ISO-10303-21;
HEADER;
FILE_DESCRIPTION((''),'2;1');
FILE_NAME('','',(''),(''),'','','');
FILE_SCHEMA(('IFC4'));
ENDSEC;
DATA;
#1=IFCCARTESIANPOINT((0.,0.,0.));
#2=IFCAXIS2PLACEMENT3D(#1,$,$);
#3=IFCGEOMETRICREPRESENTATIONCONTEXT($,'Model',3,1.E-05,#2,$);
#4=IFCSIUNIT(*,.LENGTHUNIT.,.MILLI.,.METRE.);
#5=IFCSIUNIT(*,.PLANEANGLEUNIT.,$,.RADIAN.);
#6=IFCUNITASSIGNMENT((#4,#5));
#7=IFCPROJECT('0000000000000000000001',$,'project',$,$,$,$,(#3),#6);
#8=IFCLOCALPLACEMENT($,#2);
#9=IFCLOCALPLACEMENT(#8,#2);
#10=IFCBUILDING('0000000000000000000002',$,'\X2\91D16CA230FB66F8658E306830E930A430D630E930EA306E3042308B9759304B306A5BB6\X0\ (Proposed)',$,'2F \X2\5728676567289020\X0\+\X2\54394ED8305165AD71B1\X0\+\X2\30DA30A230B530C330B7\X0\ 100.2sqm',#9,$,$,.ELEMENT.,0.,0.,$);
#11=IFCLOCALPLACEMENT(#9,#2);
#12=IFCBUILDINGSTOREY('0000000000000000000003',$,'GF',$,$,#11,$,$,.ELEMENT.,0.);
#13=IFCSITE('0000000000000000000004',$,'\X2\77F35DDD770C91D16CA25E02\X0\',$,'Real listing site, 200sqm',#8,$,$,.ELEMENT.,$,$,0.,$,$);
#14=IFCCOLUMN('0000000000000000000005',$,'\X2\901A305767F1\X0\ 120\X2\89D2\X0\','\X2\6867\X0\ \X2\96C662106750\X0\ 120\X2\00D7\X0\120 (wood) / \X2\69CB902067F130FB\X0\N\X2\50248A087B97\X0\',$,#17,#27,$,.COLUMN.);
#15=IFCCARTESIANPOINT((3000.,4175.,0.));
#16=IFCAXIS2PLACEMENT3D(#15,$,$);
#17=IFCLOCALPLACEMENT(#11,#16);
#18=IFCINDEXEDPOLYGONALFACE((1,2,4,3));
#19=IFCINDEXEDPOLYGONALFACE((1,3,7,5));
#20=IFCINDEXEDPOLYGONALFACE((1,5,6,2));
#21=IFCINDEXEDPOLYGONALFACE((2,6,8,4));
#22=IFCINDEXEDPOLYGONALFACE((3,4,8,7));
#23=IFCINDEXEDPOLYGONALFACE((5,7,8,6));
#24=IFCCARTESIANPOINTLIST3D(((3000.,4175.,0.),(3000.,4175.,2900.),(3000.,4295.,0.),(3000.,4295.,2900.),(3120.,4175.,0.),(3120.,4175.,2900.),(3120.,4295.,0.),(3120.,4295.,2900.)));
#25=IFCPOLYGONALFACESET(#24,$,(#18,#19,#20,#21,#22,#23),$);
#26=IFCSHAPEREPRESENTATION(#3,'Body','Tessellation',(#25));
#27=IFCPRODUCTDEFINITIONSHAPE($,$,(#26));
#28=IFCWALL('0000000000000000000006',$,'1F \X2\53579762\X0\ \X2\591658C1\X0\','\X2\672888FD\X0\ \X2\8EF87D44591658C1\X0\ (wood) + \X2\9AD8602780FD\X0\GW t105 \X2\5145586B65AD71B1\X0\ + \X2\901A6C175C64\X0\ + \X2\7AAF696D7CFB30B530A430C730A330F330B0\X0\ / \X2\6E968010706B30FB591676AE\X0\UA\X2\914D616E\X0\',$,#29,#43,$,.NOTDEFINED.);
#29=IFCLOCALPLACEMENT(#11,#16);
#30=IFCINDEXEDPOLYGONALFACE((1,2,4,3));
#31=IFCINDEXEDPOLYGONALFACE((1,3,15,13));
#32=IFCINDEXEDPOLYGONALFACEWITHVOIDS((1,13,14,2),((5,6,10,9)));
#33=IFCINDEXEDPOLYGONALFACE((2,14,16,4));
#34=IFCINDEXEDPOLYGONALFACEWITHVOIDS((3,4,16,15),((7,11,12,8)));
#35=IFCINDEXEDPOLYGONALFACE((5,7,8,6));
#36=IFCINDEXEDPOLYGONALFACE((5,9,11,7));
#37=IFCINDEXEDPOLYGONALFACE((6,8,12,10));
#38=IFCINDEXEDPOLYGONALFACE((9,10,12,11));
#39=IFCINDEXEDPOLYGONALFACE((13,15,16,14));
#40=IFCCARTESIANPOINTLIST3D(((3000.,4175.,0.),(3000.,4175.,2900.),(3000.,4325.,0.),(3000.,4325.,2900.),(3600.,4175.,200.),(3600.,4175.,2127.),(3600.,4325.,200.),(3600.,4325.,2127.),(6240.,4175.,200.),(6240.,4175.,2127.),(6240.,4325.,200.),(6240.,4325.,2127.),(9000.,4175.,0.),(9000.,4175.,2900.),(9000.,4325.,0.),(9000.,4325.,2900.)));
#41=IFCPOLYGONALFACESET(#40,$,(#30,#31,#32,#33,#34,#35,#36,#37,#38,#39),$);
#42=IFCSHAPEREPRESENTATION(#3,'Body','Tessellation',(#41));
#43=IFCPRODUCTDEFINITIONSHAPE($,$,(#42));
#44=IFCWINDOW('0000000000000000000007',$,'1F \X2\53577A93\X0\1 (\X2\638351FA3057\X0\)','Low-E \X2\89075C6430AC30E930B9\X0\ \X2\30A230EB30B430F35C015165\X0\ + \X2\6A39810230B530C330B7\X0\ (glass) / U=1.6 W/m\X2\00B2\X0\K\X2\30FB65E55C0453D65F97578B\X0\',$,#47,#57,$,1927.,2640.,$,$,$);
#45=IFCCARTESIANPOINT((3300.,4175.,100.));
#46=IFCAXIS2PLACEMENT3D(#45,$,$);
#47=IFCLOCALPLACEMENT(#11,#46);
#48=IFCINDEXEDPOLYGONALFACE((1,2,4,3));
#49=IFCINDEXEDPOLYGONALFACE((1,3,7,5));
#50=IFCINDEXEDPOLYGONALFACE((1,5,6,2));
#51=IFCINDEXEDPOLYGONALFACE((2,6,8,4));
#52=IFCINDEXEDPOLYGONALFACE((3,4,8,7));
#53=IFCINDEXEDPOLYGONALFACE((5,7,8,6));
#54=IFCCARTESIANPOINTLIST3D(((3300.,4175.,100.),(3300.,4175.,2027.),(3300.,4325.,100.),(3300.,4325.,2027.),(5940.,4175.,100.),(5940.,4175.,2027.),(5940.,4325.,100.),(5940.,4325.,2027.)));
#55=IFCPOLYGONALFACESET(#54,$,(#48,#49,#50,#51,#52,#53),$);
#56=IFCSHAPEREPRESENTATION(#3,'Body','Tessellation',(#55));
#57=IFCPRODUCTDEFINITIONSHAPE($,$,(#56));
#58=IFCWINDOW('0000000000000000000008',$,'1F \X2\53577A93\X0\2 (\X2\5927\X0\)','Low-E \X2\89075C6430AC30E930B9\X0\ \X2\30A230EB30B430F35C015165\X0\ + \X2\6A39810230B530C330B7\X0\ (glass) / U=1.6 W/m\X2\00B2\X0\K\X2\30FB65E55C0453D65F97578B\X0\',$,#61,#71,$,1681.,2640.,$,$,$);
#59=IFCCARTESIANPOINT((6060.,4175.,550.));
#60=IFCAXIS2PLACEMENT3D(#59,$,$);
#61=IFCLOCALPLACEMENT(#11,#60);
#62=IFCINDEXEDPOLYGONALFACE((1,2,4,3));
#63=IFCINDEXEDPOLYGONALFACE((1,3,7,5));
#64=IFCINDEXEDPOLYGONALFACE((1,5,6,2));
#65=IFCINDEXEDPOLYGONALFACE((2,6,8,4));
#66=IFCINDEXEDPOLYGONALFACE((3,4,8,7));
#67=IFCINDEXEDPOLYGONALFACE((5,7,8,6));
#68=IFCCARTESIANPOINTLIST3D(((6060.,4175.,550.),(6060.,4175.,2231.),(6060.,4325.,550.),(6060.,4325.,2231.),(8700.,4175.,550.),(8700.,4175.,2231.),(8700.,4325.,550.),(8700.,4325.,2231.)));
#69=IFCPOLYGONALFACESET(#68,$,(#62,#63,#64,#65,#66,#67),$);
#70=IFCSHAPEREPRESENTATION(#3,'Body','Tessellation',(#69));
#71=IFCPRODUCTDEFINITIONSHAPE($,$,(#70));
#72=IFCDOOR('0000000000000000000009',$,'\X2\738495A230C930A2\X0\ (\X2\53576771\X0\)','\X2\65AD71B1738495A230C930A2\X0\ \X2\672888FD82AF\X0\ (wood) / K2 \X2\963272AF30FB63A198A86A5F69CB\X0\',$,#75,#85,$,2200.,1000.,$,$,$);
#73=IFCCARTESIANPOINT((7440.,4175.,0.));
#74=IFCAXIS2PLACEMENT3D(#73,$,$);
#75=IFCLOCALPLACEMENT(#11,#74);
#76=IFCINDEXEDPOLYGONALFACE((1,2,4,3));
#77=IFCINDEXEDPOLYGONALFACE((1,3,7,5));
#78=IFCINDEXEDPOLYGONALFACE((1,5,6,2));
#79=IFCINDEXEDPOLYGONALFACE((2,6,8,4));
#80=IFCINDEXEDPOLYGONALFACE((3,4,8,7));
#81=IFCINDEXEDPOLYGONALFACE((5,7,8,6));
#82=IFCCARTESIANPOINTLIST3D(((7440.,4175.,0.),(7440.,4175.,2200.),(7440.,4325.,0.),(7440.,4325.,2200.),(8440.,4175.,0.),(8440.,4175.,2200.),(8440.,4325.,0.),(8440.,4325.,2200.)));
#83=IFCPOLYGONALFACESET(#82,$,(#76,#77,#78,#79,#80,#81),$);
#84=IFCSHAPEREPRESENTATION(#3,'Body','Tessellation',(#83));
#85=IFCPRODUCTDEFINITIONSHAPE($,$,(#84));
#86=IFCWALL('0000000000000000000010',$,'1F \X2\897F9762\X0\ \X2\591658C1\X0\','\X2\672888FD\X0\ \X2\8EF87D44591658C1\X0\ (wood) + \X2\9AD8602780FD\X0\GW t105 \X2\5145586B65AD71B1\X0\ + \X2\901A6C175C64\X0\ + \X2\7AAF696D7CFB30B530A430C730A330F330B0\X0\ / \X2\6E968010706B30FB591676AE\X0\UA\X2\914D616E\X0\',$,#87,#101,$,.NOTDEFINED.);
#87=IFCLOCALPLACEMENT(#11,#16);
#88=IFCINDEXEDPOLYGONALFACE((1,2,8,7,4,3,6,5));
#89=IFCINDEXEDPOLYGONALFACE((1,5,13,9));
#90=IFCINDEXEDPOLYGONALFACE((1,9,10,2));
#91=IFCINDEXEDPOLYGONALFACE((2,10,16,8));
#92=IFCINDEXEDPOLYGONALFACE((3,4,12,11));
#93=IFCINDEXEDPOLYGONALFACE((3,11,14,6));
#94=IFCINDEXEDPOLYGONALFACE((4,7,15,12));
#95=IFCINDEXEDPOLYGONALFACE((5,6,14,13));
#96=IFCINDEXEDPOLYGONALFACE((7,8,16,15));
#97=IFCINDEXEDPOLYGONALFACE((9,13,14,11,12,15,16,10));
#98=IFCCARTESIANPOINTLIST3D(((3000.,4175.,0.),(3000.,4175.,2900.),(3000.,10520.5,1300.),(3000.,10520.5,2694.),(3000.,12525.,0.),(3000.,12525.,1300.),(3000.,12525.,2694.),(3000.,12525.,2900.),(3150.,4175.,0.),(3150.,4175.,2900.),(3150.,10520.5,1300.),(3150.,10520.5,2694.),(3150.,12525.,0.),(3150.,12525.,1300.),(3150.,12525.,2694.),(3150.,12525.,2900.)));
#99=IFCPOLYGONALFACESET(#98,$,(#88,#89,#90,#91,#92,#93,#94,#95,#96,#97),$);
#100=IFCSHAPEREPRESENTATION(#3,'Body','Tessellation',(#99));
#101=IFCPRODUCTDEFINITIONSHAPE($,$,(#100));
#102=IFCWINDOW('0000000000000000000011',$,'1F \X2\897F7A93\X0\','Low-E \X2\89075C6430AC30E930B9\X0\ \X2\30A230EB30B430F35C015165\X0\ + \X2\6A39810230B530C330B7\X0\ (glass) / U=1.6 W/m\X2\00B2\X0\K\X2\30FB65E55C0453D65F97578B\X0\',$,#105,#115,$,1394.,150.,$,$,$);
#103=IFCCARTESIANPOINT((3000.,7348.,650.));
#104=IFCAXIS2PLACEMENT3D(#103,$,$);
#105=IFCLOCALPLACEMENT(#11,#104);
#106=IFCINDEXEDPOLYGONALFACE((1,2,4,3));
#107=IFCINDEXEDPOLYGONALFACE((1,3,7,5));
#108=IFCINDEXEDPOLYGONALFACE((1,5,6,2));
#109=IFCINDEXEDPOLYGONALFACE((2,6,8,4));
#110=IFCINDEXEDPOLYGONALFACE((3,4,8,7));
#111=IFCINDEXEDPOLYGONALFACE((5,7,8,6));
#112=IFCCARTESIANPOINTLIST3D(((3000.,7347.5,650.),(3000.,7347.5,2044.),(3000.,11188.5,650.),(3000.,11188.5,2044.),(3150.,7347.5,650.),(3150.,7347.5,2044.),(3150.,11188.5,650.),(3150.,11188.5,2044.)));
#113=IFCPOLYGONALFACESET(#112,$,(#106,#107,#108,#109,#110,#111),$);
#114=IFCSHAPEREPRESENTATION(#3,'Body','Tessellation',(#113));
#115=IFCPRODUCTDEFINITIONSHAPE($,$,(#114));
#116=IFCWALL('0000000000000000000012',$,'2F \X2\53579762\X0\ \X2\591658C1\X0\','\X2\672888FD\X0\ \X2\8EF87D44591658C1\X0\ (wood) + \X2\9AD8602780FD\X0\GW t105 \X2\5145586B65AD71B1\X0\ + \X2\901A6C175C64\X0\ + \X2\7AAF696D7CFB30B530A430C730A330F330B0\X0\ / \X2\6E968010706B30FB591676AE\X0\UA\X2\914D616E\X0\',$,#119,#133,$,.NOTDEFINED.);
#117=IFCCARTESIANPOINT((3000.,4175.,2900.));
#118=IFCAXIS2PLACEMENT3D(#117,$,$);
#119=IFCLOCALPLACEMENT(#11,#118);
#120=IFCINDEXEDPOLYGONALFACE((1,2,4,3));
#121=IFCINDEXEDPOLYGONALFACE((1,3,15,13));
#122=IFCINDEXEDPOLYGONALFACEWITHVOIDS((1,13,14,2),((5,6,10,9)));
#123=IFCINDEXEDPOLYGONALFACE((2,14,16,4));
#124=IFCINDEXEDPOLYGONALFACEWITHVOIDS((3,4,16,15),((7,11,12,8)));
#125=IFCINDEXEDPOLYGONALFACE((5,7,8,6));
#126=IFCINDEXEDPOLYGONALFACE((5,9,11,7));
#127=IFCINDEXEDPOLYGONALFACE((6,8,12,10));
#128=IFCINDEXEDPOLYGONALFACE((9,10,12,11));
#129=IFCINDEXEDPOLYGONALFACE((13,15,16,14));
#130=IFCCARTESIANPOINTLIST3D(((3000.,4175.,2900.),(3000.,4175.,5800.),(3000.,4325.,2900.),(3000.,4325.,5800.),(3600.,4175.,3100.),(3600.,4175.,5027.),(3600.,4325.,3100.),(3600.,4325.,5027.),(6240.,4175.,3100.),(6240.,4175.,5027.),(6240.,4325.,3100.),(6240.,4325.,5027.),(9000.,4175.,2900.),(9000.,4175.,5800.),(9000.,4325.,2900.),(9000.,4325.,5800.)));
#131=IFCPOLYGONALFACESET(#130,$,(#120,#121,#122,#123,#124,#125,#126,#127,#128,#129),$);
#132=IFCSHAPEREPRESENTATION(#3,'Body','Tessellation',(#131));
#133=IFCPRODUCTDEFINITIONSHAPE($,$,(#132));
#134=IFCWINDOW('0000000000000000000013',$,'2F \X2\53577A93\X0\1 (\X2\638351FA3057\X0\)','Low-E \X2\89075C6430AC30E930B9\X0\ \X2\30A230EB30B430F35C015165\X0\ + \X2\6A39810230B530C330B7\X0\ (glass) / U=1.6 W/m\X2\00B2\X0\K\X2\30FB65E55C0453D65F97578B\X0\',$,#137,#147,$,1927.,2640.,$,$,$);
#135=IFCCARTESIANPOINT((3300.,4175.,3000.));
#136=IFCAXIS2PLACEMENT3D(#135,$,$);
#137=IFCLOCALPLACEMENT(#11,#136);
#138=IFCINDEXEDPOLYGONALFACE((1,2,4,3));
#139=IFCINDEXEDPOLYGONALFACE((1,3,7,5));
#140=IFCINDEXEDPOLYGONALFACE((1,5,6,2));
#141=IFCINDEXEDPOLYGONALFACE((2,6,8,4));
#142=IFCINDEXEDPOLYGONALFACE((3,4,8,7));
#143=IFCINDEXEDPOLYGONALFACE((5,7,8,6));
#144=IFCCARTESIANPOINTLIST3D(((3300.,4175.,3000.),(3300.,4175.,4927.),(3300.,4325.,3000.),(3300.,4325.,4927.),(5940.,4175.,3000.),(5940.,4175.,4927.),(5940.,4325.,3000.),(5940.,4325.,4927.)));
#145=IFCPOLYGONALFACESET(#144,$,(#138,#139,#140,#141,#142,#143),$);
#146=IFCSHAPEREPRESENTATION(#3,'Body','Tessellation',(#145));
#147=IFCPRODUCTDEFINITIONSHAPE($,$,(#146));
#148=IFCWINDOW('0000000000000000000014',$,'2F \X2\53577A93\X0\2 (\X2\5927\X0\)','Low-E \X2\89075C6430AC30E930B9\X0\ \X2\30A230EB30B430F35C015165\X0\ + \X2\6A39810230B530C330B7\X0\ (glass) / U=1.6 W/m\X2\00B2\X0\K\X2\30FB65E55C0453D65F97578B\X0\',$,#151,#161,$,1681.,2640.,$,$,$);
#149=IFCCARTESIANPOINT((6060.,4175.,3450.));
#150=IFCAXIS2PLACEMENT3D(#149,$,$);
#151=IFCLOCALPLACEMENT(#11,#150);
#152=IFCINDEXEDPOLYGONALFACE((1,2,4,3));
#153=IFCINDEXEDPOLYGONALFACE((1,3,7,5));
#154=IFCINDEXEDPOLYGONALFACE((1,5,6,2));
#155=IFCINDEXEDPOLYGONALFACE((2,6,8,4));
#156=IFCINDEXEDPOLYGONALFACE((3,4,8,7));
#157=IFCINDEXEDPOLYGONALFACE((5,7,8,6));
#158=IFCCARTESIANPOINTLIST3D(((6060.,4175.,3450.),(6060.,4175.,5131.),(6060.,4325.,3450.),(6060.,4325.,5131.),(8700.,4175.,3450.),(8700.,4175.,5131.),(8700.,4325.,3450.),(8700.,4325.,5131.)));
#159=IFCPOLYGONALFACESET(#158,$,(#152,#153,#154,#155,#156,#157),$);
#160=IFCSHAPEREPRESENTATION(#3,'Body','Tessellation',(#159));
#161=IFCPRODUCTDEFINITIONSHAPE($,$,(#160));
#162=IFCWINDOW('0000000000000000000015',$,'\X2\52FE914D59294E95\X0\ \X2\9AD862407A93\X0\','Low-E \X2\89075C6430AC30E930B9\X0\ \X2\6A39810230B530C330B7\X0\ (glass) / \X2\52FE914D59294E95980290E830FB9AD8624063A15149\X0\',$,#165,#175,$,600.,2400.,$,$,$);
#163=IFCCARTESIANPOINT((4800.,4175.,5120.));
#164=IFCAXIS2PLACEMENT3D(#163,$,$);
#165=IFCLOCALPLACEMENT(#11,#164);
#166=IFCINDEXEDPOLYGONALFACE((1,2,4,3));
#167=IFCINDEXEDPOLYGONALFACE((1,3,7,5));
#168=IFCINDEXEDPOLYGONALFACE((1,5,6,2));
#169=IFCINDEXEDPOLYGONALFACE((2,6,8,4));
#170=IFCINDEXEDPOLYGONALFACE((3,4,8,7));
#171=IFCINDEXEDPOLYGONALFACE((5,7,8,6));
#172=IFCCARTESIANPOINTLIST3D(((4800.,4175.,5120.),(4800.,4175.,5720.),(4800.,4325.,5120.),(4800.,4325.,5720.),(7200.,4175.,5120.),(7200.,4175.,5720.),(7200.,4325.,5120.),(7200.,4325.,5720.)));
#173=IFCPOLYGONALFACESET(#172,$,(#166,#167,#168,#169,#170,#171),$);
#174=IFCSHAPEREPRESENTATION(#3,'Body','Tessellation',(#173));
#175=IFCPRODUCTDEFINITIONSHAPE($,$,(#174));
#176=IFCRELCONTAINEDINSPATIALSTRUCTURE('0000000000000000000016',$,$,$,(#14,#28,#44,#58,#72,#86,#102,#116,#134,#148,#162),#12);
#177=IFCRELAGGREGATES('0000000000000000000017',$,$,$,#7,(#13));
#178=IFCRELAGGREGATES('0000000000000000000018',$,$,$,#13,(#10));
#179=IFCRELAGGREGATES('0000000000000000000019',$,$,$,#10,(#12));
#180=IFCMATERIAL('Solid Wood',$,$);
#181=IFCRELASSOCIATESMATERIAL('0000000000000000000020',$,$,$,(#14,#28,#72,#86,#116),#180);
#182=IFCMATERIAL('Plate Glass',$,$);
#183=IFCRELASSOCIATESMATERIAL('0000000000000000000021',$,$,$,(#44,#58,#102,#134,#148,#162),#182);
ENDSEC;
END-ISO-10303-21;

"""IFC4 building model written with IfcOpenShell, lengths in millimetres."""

from ifc_helpers import new_model, si_unit, frame, frame_2d, origin, place, context, project, spatial, rectangle, extrude, material, element, fill, save


model = new_model("IFC4")

# Units and contexts
model_context = context("Model", 3, precision=1e-05, world=origin())
ifc_project = project(units=[si_unit("LENGTHUNIT", "METRE", prefix="MILLI"), si_unit("PLANEANGLEUNIT", "RADIAN")], contexts=[model_context])

# Site, building, storey
site_placement = place(None, origin())
site = spatial("IfcSite", under=ifc_project, at=site_placement, Name="石川県金沢市", ObjectType="Real listing site, 200sqm", CompositionType="ELEMENT", RefElevation=0.0)
building_placement = place(site_placement, origin())
building = spatial("IfcBuilding", under=site, at=building_placement, Name="金沢・書斎とライブラリのある静かな家 (Proposed)", ObjectType="2F 在来木造+吹付け断熱+ペアサッシ 100.2sqm", CompositionType="ELEMENT", ElevationOfRefHeight=0.0, ElevationOfTerrain=0.0)
storey_placement = place(building_placement, origin())
storey = spatial("IfcBuildingStorey", under=building, at=storey_placement, Name="GF", CompositionType="ELEMENT", Elevation=0.0)

# Column
ifc_material_1 = material(Name="Solid Wood")
column_placement = place(storey_placement, frame((3000.0, 4175.0, 0.0)))
element("IfcColumn", 1, at=column_placement, inside=storey, material=ifc_material_1, Name="通し柱 120角", Description="桧 集成材 120×120 (wood) / 構造柱・N値計算", PredefinedType="COLUMN", context=model_context, shape_type="SweptSolid", body=[
    extrude(rectangle(XDim=120.0, YDim=120.0, at=frame_2d((60.0, 60.0))), frame((3000.0, 4175.0, 0.0)), (0.0, 0.0, 1.0), 2900.0),
])

# Wall, openings, windows, door
wall_1_placement = place(storey_placement, frame((3000.0, 4175.0, 0.0)))
wall_1 = element("IfcWall", 2, at=wall_1_placement, inside=storey, material=ifc_material_1, Name="1F 南面 外壁", Description="木製 軸組外壁 (wood) + 高性能GW t105 充填断熱 + 通気層 + 窯業系サイディング / 準耐火・外皮UA配慮", PredefinedType="NOTDEFINED", context=model_context, shape_type="SweptSolid", body=[
    extrude(rectangle(XDim=6000.0, YDim=150.0, at=frame_2d((3000.0, 75.0))), frame((3000.0, 4175.0, 0.0)), (0.0, 0.0, 1.0), 2900.0),
])
opening_1_placement = place(storey_placement, frame((3300.0, 4175.0, 100.0)))
opening_1 = element("IfcOpeningElement", 3, at=opening_1_placement, cuts=wall_1, PredefinedType="NOTDEFINED", context=model_context, shape_type="SweptSolid", body=[
    extrude(rectangle(XDim=2640.0, YDim=150.0, at=frame_2d((1320.0, 75.0))), frame((3300.0, 4175.0, 100.0)), (0.0, 0.0, 1.0), 1927.0),
])
opening_2_placement = place(storey_placement, frame((6060.0, 4175.0, 550.0)))
opening_2 = element("IfcOpeningElement", 4, at=opening_2_placement, cuts=wall_1, PredefinedType="NOTDEFINED", context=model_context, shape_type="SweptSolid", body=[
    extrude(rectangle(XDim=2640.0, YDim=150.0, at=frame_2d((1320.0, 75.0))), frame((6060.0, 4175.0, 550.0)), (0.0, 0.0, 1.0), 1681.0),
])
opening_3_placement = place(storey_placement, frame((7440.0, 4175.0, 0.0)))
opening_3 = element("IfcOpeningElement", 5, at=opening_3_placement, cuts=wall_1, PredefinedType="NOTDEFINED", context=model_context, shape_type="SweptSolid", body=[
    extrude(rectangle(XDim=1000.0, YDim=150.0, at=frame_2d((500.0, 75.0))), frame((7440.0, 4175.0, 0.0)), (0.0, 0.0, 1.0), 2200.0),
])
ifc_material_2 = material(Name="Plate Glass")
window_1_placement = place(storey_placement, frame((3300.0, 4175.0, 100.0)))
window_1 = element("IfcWindow", 6, at=window_1_placement, inside=storey, material=ifc_material_2, Name="1F 南窓1 (掃出し)", Description="Low-E 複層ガラス アルゴン封入 + 樹脂サッシ (glass) / U=1.6 W/m²K・日射取得型", OverallHeight=1927.0, OverallWidth=2640.0, context=model_context, shape_type="SweptSolid", body=[
    extrude(rectangle(XDim=2640.0, YDim=150.0, at=frame_2d((1320.0, 75.0))), frame((3300.0, 4175.0, 100.0)), (0.0, 0.0, 1.0), 1927.0),
])
fill(opening_1, window_1)
window_2_placement = place(storey_placement, frame((6060.0, 4175.0, 550.0)))
window_2 = element("IfcWindow", 7, at=window_2_placement, inside=storey, material=ifc_material_2, Name="1F 南窓2 (大)", Description="Low-E 複層ガラス アルゴン封入 + 樹脂サッシ (glass) / U=1.6 W/m²K・日射取得型", OverallHeight=1681.0, OverallWidth=2640.0, context=model_context, shape_type="SweptSolid", body=[
    extrude(rectangle(XDim=2640.0, YDim=150.0, at=frame_2d((1320.0, 75.0))), frame((6060.0, 4175.0, 550.0)), (0.0, 0.0, 1.0), 1681.0),
])
fill(opening_2, window_2)
door_placement = place(storey_placement, frame((7440.0, 4175.0, 0.0)))
door = element("IfcDoor", 8, at=door_placement, inside=storey, material=ifc_material_1, Name="玄関ドア (南東)", Description="断熱玄関ドア 木製芯 (wood) / K2 防犯・採風機構", OverallHeight=2200.0, OverallWidth=1000.0, context=model_context, shape_type="SweptSolid", body=[
    extrude(rectangle(XDim=1000.0, YDim=150.0, at=frame_2d((500.0, 75.0))), frame((7440.0, 4175.0, 0.0)), (0.0, 0.0, 1.0), 2200.0),
])
fill(opening_3, door)

# Wall, opening, window
wall_2_placement = place(storey_placement, frame((3000.0, 4175.0, 0.0)))
wall_2 = element("IfcWall", 9, at=wall_2_placement, inside=storey, material=ifc_material_1, Name="1F 西面 外壁", Description="木製 軸組外壁 (wood) + 高性能GW t105 充填断熱 + 通気層 + 窯業系サイディング / 準耐火・外皮UA配慮", PredefinedType="NOTDEFINED", context=model_context, shape_type="SweptSolid", body=[
    extrude(rectangle(XDim=150.0, YDim=8350.0, at=frame_2d((75.0, 4175.0))), frame((3000.0, 4175.0, 0.0)), (0.0, 0.0, 1.0), 2900.0),
])
opening_4_placement = place(storey_placement, frame((3000.0, 7348.0, 650.0)))
opening_4 = element("IfcOpeningElement", 10, at=opening_4_placement, cuts=wall_2, PredefinedType="NOTDEFINED", context=model_context, shape_type="SweptSolid", body=[
    extrude(rectangle(XDim=150.0, YDim=3841.0, at=frame_2d((75.0, 1920.0))), frame((3000.0, 7348.0, 650.0)), (0.0, 0.0, 1.0), 1394.0),
])
window_3_placement = place(storey_placement, frame((3000.0, 7348.0, 650.0)))
window_3 = element("IfcWindow", 11, at=window_3_placement, inside=storey, material=ifc_material_2, Name="1F 西窓", Description="Low-E 複層ガラス アルゴン封入 + 樹脂サッシ (glass) / U=1.6 W/m²K・日射取得型", OverallHeight=1394.0, OverallWidth=150.0, context=model_context, shape_type="SweptSolid", body=[
    extrude(rectangle(XDim=150.0, YDim=3841.0, at=frame_2d((75.0, 1920.0))), frame((3000.0, 7348.0, 650.0)), (0.0, 0.0, 1.0), 1394.0),
])
fill(opening_4, window_3)

# Wall, openings, windows
wall_3_placement = place(storey_placement, frame((3000.0, 4175.0, 2900.0)))
wall_3 = element("IfcWall", 12, at=wall_3_placement, inside=storey, material=ifc_material_1, Name="2F 南面 外壁", Description="木製 軸組外壁 (wood) + 高性能GW t105 充填断熱 + 通気層 + 窯業系サイディング / 準耐火・外皮UA配慮", PredefinedType="NOTDEFINED", context=model_context, shape_type="SweptSolid", body=[
    extrude(rectangle(XDim=6000.0, YDim=150.0, at=frame_2d((3000.0, 75.0))), frame((3000.0, 4175.0, 2900.0)), (0.0, 0.0, 1.0), 2900.0),
])
opening_5_placement = place(storey_placement, frame((3300.0, 4175.0, 3000.0)))
opening_5 = element("IfcOpeningElement", 13, at=opening_5_placement, cuts=wall_3, PredefinedType="NOTDEFINED", context=model_context, shape_type="SweptSolid", body=[
    extrude(rectangle(XDim=2640.0, YDim=150.0, at=frame_2d((1320.0, 75.0))), frame((3300.0, 4175.0, 3000.0)), (0.0, 0.0, 1.0), 1927.0),
])
opening_6_placement = place(storey_placement, frame((6060.0, 4175.0, 3450.0)))
opening_6 = element("IfcOpeningElement", 14, at=opening_6_placement, cuts=wall_3, PredefinedType="NOTDEFINED", context=model_context, shape_type="SweptSolid", body=[
    extrude(rectangle(XDim=2640.0, YDim=150.0, at=frame_2d((1320.0, 75.0))), frame((6060.0, 4175.0, 3450.0)), (0.0, 0.0, 1.0), 1681.0),
])
opening_7_placement = place(storey_placement, frame((4800.0, 4175.0, 5120.0)))
opening_7 = element("IfcOpeningElement", 15, at=opening_7_placement, cuts=wall_3, PredefinedType="NOTDEFINED", context=model_context, shape_type="SweptSolid", body=[
    extrude(rectangle(XDim=2400.0, YDim=150.0, at=frame_2d((1200.0, 75.0))), frame((4800.0, 4175.0, 5120.0)), (0.0, 0.0, 1.0), 600.0),
])
window_4_placement = place(storey_placement, frame((3300.0, 4175.0, 3000.0)))
window_4 = element("IfcWindow", 16, at=window_4_placement, inside=storey, material=ifc_material_2, Name="2F 南窓1 (掃出し)", Description="Low-E 複層ガラス アルゴン封入 + 樹脂サッシ (glass) / U=1.6 W/m²K・日射取得型", OverallHeight=1927.0, OverallWidth=2640.0, context=model_context, shape_type="SweptSolid", body=[
    extrude(rectangle(XDim=2640.0, YDim=150.0, at=frame_2d((1320.0, 75.0))), frame((3300.0, 4175.0, 3000.0)), (0.0, 0.0, 1.0), 1927.0),
])
fill(opening_5, window_4)
window_5_placement = place(storey_placement, frame((6060.0, 4175.0, 3450.0)))
window_5 = element("IfcWindow", 17, at=window_5_placement, inside=storey, material=ifc_material_2, Name="2F 南窓2 (大)", Description="Low-E 複層ガラス アルゴン封入 + 樹脂サッシ (glass) / U=1.6 W/m²K・日射取得型", OverallHeight=1681.0, OverallWidth=2640.0, context=model_context, shape_type="SweptSolid", body=[
    extrude(rectangle(XDim=2640.0, YDim=150.0, at=frame_2d((1320.0, 75.0))), frame((6060.0, 4175.0, 3450.0)), (0.0, 0.0, 1.0), 1681.0),
])
fill(opening_6, window_5)
window_6_placement = place(storey_placement, frame((4800.0, 4175.0, 5120.0)))
window_6 = element("IfcWindow", 18, at=window_6_placement, inside=storey, material=ifc_material_2, Name="勾配天井 高所窓", Description="Low-E 複層ガラス 樹脂サッシ (glass) / 勾配天井頂部・高所採光", OverallHeight=600.0, OverallWidth=2400.0, context=model_context, shape_type="SweptSolid", body=[
    extrude(rectangle(XDim=2400.0, YDim=150.0, at=frame_2d((1200.0, 75.0))), frame((4800.0, 4175.0, 5120.0)), (0.0, 0.0, 1.0), 600.0),
])
fill(opening_7, window_6)

save(model, "model.ifc")
